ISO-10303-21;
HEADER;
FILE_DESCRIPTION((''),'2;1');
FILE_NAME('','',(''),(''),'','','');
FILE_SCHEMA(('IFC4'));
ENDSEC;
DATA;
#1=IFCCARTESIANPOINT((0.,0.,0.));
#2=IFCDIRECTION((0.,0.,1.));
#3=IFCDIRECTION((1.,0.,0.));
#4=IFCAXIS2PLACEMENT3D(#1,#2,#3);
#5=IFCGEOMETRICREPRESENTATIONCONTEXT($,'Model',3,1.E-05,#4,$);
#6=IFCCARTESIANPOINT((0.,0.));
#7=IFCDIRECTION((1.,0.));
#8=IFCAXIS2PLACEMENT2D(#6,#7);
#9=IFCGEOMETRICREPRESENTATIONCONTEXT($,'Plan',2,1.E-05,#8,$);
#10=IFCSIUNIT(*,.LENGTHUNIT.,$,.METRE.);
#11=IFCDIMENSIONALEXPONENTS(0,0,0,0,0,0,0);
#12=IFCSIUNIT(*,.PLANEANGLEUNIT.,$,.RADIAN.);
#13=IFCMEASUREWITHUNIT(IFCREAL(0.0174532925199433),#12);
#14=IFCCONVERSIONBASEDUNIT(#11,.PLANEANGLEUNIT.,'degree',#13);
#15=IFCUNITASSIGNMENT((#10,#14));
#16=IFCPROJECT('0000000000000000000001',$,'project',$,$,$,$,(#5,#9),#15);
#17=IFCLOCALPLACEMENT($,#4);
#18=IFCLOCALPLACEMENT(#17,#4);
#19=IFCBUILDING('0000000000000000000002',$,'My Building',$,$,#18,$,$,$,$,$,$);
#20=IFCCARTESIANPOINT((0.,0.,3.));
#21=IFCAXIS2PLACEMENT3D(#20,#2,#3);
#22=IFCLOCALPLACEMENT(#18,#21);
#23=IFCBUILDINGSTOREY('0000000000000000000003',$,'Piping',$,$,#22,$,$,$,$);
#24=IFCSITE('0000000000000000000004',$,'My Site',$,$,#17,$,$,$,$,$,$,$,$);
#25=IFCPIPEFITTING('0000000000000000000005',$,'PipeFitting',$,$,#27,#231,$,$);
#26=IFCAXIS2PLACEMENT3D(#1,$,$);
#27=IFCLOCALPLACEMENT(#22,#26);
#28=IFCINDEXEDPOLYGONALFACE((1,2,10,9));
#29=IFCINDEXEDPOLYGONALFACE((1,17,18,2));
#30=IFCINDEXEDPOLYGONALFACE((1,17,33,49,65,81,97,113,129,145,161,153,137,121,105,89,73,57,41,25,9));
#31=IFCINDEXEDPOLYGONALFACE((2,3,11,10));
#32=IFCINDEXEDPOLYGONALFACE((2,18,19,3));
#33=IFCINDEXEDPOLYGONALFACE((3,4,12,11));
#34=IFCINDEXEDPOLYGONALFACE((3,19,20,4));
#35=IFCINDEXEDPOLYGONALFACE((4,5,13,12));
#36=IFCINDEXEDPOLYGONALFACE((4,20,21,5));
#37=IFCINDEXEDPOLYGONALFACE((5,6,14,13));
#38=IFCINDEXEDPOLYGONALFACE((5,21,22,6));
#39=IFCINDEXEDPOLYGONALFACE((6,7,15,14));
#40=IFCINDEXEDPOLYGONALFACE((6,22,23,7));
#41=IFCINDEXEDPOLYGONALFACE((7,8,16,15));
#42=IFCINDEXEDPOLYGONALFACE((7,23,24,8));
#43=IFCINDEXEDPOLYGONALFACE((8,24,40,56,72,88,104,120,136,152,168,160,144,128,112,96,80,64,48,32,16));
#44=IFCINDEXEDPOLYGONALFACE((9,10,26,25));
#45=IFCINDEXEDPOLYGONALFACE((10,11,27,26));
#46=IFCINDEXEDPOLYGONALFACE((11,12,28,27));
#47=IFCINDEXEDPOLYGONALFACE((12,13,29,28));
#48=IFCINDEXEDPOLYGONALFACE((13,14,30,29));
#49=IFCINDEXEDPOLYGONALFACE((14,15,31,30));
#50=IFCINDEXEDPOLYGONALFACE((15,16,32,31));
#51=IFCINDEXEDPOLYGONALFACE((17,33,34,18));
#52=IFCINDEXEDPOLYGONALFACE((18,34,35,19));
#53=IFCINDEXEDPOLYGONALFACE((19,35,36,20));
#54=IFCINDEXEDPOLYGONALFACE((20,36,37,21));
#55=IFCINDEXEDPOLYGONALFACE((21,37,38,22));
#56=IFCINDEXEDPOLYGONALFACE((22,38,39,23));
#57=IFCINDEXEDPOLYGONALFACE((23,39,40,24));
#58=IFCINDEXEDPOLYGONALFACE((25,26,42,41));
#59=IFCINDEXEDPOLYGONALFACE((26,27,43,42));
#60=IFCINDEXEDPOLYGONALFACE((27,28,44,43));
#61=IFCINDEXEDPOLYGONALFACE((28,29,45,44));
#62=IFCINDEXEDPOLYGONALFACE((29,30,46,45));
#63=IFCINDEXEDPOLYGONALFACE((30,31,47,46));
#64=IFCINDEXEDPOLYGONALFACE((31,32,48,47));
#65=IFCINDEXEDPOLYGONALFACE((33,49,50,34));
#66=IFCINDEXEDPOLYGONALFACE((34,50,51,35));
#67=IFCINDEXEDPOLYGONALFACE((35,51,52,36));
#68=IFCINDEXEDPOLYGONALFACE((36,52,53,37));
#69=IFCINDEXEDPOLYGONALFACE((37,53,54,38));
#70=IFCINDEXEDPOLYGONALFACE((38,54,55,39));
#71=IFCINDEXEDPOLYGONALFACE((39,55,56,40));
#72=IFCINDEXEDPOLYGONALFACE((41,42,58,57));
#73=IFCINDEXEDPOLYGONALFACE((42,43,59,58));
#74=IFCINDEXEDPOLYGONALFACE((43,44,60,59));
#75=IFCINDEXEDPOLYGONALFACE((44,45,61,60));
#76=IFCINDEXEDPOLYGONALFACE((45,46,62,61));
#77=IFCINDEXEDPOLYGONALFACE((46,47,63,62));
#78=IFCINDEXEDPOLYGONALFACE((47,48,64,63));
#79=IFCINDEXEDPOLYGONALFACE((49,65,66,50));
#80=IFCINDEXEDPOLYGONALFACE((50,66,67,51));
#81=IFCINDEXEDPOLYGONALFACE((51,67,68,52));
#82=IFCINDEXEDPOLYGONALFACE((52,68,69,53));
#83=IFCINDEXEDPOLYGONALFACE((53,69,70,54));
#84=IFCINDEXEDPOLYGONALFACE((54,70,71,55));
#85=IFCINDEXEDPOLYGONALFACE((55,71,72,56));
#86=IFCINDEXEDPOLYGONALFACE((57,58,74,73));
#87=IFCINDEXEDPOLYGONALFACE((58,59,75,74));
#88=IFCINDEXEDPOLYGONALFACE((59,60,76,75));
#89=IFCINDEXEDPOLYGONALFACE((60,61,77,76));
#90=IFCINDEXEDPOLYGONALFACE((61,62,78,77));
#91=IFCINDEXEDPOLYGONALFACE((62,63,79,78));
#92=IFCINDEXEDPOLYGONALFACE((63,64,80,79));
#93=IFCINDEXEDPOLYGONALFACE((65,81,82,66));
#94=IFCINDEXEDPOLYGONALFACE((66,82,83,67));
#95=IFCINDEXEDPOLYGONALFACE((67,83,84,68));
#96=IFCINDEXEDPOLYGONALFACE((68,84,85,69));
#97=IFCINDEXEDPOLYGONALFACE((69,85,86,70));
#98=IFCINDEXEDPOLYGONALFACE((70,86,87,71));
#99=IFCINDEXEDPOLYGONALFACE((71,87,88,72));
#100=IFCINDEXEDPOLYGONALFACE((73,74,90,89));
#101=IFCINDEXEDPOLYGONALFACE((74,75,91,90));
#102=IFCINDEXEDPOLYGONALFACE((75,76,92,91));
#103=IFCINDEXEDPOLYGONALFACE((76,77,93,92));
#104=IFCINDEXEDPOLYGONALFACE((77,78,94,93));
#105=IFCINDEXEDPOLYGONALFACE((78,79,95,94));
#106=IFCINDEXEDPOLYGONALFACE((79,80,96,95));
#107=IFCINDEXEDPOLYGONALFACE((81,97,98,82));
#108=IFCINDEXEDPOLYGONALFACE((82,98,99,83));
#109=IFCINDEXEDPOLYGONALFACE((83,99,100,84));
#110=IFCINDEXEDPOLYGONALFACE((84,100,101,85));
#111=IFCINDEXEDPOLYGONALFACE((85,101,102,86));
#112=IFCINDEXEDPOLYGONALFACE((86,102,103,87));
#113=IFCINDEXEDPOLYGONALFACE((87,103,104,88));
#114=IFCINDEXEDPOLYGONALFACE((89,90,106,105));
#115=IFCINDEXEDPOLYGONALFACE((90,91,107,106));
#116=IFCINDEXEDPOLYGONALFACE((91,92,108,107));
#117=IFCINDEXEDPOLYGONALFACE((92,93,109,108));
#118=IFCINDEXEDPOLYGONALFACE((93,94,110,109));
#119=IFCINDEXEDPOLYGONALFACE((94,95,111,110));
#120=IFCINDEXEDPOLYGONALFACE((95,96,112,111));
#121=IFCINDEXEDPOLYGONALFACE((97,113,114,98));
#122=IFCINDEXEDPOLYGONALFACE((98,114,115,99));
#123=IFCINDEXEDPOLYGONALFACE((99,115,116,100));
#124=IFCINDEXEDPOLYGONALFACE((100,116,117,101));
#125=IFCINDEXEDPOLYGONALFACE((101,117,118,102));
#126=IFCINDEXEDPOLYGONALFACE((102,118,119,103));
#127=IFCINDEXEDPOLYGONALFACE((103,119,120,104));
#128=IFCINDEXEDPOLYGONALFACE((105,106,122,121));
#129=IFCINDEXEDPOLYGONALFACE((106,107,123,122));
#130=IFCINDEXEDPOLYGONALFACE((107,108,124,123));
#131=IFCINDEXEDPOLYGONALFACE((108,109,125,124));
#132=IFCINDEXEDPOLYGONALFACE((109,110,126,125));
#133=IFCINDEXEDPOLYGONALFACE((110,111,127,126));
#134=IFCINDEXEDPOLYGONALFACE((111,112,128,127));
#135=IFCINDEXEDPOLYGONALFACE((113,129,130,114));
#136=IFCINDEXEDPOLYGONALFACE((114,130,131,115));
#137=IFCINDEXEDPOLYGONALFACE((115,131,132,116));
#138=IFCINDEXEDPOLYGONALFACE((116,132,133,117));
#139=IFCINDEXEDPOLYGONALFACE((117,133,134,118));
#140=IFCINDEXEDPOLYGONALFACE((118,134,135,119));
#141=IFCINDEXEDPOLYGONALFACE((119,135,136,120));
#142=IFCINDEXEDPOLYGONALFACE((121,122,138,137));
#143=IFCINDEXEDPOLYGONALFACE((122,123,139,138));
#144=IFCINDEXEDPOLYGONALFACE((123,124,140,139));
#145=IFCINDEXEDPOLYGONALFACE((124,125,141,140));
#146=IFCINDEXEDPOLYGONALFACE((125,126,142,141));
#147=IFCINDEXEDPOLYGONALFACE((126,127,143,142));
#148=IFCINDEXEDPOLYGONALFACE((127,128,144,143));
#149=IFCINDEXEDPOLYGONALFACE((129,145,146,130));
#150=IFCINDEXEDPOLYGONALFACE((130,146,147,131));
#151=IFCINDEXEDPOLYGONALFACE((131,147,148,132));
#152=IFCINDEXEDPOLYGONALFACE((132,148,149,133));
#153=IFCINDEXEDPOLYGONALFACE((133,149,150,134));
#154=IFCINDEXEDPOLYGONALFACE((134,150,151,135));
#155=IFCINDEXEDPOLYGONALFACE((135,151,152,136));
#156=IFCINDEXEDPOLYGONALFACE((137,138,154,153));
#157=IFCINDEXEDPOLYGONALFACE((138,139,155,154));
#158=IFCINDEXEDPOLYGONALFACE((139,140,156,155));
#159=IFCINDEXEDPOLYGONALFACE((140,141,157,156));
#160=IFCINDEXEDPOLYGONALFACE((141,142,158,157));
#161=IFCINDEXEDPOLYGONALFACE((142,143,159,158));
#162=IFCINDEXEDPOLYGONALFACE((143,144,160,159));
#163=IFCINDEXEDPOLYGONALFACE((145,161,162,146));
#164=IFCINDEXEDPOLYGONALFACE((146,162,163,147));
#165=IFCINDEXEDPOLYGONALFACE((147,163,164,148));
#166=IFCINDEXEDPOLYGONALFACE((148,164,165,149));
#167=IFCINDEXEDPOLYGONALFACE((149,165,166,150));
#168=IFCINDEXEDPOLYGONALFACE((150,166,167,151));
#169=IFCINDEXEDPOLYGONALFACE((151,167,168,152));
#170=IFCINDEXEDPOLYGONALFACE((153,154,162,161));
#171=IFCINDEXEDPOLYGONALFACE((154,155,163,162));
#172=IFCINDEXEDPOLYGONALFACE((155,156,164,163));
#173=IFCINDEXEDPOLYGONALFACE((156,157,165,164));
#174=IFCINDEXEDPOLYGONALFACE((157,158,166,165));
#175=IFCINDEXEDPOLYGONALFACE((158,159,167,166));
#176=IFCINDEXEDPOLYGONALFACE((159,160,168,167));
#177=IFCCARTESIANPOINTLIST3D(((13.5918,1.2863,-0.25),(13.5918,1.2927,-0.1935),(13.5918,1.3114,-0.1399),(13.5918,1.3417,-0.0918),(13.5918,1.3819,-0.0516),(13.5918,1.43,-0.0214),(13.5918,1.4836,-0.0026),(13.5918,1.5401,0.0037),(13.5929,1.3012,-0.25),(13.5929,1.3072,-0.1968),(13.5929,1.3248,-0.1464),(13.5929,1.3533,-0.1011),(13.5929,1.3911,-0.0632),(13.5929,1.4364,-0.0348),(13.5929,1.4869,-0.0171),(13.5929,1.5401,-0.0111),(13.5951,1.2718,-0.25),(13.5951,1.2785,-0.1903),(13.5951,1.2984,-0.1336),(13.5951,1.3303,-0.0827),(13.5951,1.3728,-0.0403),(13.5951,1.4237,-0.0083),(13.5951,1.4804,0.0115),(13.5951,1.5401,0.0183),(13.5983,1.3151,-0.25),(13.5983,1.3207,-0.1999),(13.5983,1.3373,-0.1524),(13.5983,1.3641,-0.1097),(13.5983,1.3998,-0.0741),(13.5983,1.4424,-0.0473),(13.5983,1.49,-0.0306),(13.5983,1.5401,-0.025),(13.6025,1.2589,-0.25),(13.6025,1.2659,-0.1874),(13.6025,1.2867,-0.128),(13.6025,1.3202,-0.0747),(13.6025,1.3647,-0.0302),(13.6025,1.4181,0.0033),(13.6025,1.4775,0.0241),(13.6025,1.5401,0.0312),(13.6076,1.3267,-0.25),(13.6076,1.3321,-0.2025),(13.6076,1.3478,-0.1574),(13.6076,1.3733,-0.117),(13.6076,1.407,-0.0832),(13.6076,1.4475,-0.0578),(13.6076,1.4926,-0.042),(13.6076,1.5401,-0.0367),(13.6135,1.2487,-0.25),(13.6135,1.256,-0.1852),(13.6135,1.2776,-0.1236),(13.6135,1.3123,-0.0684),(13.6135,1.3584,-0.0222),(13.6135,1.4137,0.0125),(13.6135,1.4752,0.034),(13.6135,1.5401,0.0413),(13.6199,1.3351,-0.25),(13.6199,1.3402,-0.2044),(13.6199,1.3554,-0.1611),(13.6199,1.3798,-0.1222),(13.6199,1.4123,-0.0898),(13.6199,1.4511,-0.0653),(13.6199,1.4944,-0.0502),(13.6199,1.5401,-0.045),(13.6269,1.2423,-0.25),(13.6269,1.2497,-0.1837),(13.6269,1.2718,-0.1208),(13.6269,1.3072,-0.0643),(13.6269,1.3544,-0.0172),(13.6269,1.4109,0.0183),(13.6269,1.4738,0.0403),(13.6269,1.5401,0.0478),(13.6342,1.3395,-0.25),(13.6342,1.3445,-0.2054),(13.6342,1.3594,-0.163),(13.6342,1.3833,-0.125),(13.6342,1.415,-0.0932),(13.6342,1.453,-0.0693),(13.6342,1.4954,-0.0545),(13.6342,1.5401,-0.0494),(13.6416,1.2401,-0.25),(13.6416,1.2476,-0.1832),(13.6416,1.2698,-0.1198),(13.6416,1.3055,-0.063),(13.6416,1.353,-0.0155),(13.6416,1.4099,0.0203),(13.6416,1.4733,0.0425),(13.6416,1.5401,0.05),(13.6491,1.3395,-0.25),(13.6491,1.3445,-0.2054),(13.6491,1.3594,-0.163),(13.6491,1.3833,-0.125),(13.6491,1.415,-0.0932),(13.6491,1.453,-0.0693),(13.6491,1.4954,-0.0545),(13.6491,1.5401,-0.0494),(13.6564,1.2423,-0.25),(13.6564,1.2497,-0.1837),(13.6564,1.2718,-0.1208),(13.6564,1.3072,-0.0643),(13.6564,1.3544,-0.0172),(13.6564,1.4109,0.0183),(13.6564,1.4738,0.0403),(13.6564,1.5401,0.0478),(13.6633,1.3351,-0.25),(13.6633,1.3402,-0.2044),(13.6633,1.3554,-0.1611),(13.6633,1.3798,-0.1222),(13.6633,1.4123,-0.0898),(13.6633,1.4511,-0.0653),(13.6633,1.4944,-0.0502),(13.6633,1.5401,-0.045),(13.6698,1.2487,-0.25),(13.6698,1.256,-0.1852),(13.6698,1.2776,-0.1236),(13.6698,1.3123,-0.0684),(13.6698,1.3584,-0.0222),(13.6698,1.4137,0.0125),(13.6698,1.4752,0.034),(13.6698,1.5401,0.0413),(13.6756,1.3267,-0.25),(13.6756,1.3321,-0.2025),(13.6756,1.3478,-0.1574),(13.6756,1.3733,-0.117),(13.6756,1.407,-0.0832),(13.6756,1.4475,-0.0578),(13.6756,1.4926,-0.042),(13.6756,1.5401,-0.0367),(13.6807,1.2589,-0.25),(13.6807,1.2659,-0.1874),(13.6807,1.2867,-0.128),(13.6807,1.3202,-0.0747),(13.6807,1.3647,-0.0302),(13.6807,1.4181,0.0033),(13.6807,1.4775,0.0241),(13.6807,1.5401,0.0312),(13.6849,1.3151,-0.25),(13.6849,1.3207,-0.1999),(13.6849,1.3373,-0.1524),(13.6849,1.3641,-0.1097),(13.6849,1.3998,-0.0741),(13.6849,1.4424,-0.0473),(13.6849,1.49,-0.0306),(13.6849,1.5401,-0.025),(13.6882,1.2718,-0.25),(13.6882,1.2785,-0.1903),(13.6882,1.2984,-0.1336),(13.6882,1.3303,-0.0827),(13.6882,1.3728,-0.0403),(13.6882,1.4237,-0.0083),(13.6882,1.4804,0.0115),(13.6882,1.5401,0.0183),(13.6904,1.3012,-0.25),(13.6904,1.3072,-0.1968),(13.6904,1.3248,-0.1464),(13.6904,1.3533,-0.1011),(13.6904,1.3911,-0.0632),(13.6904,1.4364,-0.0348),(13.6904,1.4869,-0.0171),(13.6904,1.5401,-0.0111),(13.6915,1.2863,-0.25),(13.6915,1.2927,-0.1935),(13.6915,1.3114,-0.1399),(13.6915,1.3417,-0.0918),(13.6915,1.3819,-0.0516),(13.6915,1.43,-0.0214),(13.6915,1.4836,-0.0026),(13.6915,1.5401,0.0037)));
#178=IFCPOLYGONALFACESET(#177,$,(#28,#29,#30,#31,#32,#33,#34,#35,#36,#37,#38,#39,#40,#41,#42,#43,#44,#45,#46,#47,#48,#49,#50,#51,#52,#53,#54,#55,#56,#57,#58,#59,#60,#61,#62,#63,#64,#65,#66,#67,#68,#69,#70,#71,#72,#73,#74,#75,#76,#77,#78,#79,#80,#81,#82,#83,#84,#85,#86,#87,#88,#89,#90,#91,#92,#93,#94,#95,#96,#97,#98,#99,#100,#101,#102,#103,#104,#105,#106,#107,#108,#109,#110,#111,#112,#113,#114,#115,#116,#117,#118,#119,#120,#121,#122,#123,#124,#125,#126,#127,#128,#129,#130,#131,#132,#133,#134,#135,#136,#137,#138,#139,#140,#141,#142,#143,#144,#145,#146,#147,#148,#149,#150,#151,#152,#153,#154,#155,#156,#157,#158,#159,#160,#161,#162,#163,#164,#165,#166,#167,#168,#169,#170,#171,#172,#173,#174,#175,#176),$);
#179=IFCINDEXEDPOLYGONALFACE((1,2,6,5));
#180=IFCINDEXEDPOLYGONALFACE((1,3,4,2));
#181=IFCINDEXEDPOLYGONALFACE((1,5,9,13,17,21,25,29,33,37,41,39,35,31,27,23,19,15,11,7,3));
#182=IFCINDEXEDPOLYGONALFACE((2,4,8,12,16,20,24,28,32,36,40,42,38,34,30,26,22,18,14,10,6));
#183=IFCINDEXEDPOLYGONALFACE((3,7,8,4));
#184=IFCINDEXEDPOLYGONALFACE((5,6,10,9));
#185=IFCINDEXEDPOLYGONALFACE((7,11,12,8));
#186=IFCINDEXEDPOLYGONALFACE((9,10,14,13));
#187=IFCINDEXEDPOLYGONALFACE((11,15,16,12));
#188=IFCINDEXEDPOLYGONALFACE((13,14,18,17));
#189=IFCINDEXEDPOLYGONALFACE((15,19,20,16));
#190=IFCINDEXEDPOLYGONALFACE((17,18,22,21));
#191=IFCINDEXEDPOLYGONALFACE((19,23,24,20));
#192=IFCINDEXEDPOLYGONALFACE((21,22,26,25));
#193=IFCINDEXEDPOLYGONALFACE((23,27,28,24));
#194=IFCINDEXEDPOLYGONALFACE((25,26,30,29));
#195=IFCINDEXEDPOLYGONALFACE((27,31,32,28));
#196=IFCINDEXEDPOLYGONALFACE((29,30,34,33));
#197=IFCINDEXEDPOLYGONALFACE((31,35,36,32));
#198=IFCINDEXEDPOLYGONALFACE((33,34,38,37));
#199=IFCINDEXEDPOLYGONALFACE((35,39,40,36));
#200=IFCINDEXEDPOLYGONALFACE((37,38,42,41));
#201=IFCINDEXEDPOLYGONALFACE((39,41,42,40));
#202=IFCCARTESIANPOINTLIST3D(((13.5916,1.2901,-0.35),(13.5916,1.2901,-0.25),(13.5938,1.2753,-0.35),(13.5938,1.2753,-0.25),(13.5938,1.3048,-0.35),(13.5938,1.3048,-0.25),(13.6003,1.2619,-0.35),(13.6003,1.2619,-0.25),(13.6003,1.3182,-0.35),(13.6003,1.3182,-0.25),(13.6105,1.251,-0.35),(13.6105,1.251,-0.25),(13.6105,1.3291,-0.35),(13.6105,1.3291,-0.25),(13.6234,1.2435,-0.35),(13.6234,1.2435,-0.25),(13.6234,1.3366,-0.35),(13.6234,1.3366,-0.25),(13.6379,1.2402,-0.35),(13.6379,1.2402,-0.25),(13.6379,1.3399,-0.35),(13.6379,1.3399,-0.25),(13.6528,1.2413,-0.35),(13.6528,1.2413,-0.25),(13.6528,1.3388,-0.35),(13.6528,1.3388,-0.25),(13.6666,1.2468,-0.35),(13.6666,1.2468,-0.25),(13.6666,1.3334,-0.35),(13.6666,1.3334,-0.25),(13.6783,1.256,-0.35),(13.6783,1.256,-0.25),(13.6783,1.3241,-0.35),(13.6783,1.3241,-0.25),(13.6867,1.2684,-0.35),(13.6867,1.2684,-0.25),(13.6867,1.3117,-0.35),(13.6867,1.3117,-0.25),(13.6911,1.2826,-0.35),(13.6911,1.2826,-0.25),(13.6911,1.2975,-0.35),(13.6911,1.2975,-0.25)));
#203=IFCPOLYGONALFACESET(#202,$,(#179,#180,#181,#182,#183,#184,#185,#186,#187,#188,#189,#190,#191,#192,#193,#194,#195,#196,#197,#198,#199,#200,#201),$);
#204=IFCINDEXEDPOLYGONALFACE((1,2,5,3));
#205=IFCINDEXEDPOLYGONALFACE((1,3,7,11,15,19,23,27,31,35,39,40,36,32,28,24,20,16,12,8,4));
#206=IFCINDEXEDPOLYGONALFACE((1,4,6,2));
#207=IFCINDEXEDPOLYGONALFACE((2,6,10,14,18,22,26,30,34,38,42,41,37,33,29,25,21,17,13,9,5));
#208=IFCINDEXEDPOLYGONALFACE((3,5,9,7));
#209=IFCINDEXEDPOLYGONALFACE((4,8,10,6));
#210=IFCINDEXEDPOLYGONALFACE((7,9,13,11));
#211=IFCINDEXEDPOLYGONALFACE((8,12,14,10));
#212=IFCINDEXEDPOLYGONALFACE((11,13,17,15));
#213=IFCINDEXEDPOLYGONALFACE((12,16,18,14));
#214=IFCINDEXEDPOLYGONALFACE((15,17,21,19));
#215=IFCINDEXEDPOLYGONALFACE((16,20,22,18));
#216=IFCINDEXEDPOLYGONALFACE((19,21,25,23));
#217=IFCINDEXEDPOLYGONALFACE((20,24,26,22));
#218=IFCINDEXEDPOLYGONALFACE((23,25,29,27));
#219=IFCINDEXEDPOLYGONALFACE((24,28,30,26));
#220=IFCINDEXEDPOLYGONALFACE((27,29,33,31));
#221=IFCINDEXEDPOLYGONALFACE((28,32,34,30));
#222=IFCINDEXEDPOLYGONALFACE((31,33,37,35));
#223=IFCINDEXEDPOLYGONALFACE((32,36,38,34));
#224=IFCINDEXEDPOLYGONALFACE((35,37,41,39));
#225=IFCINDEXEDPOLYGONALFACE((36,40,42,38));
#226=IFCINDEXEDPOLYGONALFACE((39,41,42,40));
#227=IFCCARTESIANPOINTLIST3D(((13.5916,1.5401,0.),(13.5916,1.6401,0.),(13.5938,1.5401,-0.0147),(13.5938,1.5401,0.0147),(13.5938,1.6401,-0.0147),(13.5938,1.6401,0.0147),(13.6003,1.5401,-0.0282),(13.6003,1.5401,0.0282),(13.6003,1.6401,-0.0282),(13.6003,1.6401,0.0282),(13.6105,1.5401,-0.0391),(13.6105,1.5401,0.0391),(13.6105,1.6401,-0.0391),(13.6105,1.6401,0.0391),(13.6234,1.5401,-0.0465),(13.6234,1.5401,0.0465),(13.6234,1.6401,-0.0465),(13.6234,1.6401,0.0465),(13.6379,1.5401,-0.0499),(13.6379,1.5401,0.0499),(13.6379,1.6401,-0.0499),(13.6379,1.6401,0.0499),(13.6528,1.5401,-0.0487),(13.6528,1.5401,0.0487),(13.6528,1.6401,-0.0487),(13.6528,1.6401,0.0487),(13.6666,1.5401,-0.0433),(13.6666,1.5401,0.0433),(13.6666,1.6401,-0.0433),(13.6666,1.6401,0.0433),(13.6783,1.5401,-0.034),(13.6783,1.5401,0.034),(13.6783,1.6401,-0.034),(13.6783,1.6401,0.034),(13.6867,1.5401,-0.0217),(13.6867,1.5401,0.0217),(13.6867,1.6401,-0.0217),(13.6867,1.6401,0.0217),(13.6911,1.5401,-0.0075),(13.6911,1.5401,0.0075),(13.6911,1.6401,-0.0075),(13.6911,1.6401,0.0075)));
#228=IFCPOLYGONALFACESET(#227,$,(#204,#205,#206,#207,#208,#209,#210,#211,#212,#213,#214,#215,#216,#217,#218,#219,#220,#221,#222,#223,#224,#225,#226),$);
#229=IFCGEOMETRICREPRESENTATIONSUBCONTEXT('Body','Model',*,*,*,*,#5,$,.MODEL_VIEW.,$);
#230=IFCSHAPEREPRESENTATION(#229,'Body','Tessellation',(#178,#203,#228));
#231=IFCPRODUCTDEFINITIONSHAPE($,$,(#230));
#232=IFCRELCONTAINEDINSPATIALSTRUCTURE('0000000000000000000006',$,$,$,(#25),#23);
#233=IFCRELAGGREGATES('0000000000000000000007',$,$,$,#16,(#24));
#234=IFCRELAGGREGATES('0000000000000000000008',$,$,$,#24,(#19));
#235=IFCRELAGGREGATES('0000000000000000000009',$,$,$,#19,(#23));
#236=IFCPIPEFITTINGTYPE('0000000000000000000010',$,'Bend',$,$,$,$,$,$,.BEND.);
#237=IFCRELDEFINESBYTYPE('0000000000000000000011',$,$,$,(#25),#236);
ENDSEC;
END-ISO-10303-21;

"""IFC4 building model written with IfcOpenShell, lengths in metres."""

from ifc_helpers import new_model, entity, si_unit, converted_unit, frame, origin_with_axes, origin_2d_with_axis, place, context, subcontext, project, spatial, circle, extrude, source, transform, mapped, type_object, type_shapes, element, save


model = new_model("IFC4")

# Units and contexts
model_context = context("Model", 3, precision=1e-05, world=origin_with_axes())
plan_context = context("Plan", 2, precision=1e-05, world=origin_2d_with_axis())
body_context = subcontext(model_context, "Body", "Model", "MODEL_VIEW")
ifc_project = project(units=[si_unit("LENGTHUNIT", "METRE"), converted_unit("PLANEANGLEUNIT", "degree", entity("IfcReal", 0.0174532925199433), si_unit("PLANEANGLEUNIT", "RADIAN"), dimensions=[0, 0, 0, 0, 0, 0, 0])], contexts=[model_context, plan_context])

# Site, building, storey
site_placement = place(None, origin_with_axes())
site = spatial("IfcSite", under=ifc_project, at=site_placement, Name="My Site")
building_placement = place(site_placement, origin_with_axes())
building = spatial("IfcBuilding", under=site, at=building_placement, Name="My Building")
storey_placement = place(building_placement, frame((0.0, 0.0, 3.0), z_axis=(0.0, 0.0, 1.0), x_axis=(1.0, 0.0, 0.0)))
storey = spatial("IfcBuildingStorey", under=building, at=storey_placement, Name="Piping")

# Pipe fitting
pipe_fitting_type_1 = type_object("IfcPipeFittingType", Name="Bend", PredefinedType="BEND")
shared_shape = source(origin_with_axes(), body_context, "Body", "SolidModel", [
    entity("IfcSweptDiskSolid", entity("IfcIndexedPolyCurve", entity("IfcCartesianPointList3D", [[0.0, 0.0, -0.1], [0.0, 0.0732, -0.2768], [0.0, 0.25, -0.35]]), [entity("IfcArcIndex", [1, 2, 3])]), 0.05),
    extrude(circle(Radius=0.05), origin_with_axes(), (0.0, 0.0, -1.0), 0.1),
    extrude(circle(Radius=0.05), frame((0.0, 0.25, -0.35), z_axis=(0.0, 1.0, 0.0), x_axis=(1.0, 0.0, 0.0)), (0.0, 0.0, 1.0), 0.1),
])
type_shapes(pipe_fitting_type_1, [shared_shape])
for number, where, z_axis, x_axis, name in (
    (1, (13.6416, 1.2901, -0.35), (0.0, 0.0, -1.0), (-1.0, 0.0, 0.0), "PipeFitting"),
):
    element("IfcPipeFitting", number, at=place(storey_placement, frame(where, z_axis=z_axis, x_axis=x_axis)), inside=storey, type_object=pipe_fitting_type_1, Name=name, context=body_context, shape_type="MappedRepresentation", body=[
        mapped(shared_shape, transform((0.0, 0.0, 0.0), x_axis=(1.0, 0.0, 0.0), y_axis=(0.0, 1.0, 0.0), z_axis=(0.0, 0.0, 1.0), scale=1.0)),
    ])

save(model, "model.ifc")
